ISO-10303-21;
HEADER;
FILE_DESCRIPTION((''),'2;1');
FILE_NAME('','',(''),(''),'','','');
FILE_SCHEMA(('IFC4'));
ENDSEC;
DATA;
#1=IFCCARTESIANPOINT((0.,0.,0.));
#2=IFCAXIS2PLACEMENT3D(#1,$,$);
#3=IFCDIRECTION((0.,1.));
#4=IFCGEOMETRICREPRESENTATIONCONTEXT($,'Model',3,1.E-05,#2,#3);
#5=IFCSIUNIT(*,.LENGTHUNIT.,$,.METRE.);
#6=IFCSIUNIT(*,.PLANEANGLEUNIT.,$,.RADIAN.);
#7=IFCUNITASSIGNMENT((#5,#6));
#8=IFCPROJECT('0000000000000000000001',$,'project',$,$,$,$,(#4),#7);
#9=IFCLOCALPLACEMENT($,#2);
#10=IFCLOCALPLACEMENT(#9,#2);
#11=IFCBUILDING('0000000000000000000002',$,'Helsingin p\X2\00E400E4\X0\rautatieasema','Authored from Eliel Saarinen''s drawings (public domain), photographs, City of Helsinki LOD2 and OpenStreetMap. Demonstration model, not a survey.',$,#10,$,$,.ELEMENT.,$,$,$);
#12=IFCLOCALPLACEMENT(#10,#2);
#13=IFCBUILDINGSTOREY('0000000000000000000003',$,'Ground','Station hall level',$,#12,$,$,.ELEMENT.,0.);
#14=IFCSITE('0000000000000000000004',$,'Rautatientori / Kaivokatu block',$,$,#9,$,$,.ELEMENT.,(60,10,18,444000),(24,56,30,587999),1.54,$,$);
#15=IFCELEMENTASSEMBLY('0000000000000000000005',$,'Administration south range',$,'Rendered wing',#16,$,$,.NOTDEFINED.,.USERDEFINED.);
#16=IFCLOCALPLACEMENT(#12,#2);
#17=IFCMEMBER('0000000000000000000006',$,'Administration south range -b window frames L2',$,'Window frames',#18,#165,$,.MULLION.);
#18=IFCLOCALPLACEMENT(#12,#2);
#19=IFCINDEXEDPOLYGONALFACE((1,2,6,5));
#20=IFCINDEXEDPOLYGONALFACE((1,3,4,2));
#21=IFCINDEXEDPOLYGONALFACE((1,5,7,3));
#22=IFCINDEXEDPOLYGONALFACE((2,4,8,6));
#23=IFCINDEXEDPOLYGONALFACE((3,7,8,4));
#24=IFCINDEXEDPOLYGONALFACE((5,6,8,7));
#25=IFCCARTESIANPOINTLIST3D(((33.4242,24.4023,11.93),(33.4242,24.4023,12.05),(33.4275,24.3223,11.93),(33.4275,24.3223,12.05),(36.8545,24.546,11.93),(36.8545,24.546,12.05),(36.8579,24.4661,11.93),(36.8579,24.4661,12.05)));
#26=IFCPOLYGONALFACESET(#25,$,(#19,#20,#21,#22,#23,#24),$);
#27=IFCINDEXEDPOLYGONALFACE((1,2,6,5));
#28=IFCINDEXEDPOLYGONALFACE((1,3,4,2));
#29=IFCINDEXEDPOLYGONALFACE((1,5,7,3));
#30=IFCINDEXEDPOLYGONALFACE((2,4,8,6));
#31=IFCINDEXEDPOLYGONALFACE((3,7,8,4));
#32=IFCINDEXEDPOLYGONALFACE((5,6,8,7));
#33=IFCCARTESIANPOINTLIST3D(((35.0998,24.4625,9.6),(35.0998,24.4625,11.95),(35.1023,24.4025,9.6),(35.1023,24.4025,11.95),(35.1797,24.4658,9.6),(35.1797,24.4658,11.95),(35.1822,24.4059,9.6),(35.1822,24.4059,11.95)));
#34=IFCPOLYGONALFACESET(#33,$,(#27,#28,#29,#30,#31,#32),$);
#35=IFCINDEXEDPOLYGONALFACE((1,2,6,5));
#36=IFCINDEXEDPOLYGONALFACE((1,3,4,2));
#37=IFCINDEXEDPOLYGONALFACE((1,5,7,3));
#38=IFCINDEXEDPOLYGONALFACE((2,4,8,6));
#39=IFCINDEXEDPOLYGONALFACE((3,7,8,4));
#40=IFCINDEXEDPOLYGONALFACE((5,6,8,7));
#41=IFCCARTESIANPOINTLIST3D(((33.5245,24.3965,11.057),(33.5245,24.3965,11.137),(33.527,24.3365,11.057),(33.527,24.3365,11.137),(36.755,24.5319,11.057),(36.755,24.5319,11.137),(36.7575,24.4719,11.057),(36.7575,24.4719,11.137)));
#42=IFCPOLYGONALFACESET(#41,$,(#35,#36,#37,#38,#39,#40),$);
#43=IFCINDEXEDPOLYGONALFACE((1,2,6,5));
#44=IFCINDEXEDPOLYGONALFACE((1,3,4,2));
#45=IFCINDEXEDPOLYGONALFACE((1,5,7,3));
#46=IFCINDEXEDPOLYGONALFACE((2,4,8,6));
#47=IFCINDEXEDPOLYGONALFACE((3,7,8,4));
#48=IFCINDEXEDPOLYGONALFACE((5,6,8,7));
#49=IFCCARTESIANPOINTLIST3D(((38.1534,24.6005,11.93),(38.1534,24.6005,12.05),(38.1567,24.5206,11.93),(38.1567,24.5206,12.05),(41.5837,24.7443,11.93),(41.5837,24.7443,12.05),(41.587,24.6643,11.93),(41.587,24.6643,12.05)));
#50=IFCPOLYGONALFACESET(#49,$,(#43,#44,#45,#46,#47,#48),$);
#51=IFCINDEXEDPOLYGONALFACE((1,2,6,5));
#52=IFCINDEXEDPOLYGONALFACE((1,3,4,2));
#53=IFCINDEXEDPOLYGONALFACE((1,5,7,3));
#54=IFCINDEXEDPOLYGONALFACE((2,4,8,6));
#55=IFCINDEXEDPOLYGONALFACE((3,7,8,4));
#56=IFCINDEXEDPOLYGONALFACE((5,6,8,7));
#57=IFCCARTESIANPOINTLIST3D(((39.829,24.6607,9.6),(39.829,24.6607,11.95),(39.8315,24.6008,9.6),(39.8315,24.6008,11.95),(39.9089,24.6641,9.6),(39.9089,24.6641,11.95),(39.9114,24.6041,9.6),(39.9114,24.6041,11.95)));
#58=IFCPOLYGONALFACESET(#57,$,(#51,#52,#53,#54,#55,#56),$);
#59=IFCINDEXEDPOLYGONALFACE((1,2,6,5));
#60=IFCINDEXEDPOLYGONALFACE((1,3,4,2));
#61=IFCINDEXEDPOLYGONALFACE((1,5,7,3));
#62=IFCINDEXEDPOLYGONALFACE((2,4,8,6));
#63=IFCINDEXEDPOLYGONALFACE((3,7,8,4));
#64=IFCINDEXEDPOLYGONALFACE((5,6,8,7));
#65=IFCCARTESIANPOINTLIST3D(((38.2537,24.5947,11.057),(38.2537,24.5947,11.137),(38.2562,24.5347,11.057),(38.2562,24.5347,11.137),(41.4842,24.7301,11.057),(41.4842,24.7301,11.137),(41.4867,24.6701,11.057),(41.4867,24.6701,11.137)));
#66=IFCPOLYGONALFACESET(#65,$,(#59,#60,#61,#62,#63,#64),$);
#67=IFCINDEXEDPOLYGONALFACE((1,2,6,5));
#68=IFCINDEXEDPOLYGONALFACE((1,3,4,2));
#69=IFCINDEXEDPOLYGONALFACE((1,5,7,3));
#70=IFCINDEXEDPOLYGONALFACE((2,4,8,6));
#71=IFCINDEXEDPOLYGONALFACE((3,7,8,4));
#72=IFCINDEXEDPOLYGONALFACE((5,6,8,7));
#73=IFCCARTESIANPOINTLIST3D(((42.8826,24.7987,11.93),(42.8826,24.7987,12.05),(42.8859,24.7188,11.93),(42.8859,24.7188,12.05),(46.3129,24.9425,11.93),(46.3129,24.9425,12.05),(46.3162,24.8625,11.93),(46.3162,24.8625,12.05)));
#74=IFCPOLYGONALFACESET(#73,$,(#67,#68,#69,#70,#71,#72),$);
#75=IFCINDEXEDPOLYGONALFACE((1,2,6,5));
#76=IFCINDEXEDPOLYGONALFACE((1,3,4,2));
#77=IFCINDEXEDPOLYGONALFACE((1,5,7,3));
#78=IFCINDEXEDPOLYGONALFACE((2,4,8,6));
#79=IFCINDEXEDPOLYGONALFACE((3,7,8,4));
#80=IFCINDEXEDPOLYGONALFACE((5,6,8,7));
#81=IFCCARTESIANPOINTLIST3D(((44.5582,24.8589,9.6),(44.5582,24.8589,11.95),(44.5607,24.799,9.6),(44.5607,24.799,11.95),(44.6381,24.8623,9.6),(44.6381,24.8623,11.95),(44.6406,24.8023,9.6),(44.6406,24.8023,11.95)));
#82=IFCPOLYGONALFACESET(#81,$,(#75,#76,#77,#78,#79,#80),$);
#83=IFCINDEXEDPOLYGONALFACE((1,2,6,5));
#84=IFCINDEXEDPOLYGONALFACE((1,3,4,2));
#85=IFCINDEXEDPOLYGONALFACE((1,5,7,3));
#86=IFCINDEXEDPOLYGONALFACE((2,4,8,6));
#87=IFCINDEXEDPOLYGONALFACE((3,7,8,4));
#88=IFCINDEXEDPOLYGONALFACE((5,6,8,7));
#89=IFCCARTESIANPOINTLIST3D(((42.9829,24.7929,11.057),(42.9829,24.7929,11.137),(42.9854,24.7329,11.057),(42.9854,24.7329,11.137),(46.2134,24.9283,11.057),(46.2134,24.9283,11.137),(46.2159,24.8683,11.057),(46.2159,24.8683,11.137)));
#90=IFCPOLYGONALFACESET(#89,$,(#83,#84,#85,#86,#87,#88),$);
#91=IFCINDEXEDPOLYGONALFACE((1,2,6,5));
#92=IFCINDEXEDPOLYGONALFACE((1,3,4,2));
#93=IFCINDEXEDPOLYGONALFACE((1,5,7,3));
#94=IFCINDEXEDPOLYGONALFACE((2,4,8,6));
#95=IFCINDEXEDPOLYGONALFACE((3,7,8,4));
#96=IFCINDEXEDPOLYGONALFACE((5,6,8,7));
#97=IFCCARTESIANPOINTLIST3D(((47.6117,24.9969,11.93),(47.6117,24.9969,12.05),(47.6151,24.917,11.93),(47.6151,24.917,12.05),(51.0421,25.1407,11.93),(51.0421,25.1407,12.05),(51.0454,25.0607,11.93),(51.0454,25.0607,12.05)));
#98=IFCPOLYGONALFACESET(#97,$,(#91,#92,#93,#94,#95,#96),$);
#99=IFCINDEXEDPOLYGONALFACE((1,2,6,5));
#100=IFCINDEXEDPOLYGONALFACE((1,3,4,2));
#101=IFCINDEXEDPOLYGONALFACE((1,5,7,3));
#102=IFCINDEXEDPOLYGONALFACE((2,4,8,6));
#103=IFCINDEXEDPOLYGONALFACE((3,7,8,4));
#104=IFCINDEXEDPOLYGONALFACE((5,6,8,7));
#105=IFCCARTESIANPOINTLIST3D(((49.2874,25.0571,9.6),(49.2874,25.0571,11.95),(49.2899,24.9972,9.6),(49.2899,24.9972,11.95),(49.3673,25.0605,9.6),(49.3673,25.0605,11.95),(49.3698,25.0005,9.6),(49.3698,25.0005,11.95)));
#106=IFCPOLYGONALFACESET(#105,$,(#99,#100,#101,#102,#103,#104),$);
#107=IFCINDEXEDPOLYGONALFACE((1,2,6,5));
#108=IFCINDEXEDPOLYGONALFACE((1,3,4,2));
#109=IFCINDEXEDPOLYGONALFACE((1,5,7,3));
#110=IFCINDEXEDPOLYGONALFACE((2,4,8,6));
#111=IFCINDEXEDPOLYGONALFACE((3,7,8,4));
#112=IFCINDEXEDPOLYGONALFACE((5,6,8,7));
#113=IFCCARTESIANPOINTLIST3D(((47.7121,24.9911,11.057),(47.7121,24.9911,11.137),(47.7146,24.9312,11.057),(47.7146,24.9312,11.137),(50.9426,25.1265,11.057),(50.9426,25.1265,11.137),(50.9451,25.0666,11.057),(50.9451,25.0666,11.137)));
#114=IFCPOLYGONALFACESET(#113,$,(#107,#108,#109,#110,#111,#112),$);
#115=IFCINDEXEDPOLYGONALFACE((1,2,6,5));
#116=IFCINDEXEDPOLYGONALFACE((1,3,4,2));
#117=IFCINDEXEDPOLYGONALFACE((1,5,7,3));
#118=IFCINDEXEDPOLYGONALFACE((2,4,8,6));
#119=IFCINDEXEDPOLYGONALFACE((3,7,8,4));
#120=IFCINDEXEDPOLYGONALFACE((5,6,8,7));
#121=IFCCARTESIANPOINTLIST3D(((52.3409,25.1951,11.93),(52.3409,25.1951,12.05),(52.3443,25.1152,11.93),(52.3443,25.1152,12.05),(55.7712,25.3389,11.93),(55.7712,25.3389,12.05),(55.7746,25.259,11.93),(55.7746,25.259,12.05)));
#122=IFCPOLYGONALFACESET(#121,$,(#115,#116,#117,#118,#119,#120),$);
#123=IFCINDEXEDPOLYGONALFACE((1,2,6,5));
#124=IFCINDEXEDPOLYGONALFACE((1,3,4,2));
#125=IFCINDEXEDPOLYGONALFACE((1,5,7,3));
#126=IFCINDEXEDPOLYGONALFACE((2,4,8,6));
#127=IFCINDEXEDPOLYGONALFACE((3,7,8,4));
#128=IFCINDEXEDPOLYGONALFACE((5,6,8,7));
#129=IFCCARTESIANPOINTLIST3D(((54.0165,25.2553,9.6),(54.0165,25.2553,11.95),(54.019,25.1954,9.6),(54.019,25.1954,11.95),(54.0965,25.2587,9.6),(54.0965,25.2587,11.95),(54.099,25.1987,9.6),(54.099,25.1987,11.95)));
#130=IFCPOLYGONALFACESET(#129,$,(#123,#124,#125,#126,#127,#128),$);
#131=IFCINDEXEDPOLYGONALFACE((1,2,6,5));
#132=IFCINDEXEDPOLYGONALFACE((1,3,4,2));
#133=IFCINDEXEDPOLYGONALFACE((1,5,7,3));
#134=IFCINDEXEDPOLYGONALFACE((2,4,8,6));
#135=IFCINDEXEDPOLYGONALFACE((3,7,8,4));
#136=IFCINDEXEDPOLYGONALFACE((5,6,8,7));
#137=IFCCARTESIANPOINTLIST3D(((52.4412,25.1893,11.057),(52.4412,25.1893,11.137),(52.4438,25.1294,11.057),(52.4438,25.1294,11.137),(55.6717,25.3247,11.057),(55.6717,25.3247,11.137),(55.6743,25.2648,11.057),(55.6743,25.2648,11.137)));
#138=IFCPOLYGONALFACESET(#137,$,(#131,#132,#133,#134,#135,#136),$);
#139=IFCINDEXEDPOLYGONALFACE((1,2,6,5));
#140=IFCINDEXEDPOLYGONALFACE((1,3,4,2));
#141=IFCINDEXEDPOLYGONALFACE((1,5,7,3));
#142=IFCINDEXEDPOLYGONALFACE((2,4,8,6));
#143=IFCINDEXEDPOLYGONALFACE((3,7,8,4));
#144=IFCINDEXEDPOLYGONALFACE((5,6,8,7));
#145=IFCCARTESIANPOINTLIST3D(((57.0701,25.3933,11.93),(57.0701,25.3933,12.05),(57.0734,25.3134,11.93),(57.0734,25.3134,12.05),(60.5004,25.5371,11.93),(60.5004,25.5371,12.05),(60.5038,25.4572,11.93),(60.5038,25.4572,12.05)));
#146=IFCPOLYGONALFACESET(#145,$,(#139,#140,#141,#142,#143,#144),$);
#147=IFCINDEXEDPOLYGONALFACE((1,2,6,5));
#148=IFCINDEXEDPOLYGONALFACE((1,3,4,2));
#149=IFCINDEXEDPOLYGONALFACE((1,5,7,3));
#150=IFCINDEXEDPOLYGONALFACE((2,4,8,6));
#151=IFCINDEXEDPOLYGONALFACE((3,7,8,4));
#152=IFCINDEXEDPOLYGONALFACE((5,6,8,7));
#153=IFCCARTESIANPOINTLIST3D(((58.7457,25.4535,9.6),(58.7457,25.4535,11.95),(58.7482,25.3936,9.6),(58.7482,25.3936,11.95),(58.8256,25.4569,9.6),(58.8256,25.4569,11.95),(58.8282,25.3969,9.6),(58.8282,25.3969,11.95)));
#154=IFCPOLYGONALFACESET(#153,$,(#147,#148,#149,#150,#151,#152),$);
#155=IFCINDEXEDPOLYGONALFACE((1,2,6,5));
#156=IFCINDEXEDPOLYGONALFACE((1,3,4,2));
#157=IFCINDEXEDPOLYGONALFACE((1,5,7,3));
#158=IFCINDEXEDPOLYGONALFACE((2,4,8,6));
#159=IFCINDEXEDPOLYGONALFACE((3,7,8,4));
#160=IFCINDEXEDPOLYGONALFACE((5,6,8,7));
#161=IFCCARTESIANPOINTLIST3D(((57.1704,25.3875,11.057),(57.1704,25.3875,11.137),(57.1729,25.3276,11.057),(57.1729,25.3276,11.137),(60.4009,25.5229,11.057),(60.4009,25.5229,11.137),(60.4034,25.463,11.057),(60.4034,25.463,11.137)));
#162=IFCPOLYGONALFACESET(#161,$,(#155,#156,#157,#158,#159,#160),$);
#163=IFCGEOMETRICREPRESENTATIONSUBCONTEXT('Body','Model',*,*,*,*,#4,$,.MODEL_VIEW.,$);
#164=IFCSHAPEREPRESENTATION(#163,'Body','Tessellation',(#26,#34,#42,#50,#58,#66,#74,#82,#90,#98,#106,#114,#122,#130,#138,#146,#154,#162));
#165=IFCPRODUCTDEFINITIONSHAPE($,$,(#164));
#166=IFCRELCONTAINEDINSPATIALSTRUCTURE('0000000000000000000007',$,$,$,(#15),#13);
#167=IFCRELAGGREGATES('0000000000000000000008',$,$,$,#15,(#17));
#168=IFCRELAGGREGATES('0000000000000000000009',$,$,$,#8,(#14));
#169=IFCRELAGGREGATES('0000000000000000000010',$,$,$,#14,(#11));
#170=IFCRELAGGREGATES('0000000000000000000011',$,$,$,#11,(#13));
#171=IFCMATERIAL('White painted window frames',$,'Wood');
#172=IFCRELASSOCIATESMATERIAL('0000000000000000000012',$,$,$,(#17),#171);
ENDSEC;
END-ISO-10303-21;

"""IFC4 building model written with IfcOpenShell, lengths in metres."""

from ifc_helpers import new_model, si_unit, direction, frame, frame_2d, origin, place, context, subcontext, project, spatial, rectangle, extrude, material, element, aggregate, save


model = new_model("IFC4")

# Units and contexts
model_context = context("Model", 3, precision=1e-05, world=origin(), true_north=direction((0.0, 1.0)))
body_context = subcontext(model_context, "Body", "Model", "MODEL_VIEW")
ifc_project = project(units=[si_unit("LENGTHUNIT", "METRE"), si_unit("PLANEANGLEUNIT", "RADIAN")], contexts=[model_context])

# Site, building, storey
site_placement = place(None, origin())
site = spatial("IfcSite", under=ifc_project, at=site_placement, Name="Rautatientori / Kaivokatu block", CompositionType="ELEMENT", RefLatitude=(60, 10, 18, 444000), RefLongitude=(24, 56, 30, 587999), RefElevation=1.54)
building_placement = place(site_placement, origin())
building = spatial("IfcBuilding", under=site, at=building_placement, Name="Helsingin päärautatieasema", Description="Authored from Eliel Saarinen's drawings (public domain), photographs, City of Helsinki LOD2 and OpenStreetMap. Demonstration model, not a survey.", CompositionType="ELEMENT")
storey_placement = place(building_placement, origin())
storey = spatial("IfcBuildingStorey", under=building, at=storey_placement, Name="Ground", Description="Station hall level", CompositionType="ELEMENT", Elevation=0.0)

# Element assembly, member
assembly_1_placement = place(building_placement, origin())
assembly_1 = element("IfcElementAssembly", 1, at=assembly_1_placement, inside=storey, Name="Administration south range", ObjectType="Rendered wing", AssemblyPlace="NOTDEFINED", PredefinedType="USERDEFINED")
ifc_material_1 = material(Name="White painted window frames", Category="Wood")
member_1_placement = place(building_placement, origin())
member_1 = element("IfcMember", 2, at=member_1_placement, material=ifc_material_1, Name="Administration south range -b window frames L2", ObjectType="Window frames", PredefinedType="MULLION", context=body_context, shape_type="SweptSolid", body=[
    extrude(rectangle(XDim=3.4333, YDim=0.08, at=frame_2d((0.0, 0.0), x_axis=(0.999123, 0.041876))), frame((35.141, 24.4342, 11.93)), (0.0, 0.0, 1.0), 0.12),
    extrude(rectangle(XDim=0.08, YDim=0.06, at=frame_2d((0.0, 0.0), x_axis=(0.999123, 0.041876))), frame((35.141, 24.4342, 9.6)), (0.0, 0.0, 1.0), 2.35),
    extrude(rectangle(XDim=3.2333, YDim=0.06, at=frame_2d((0.0, 0.0), x_axis=(0.999123, 0.041876))), frame((35.141, 24.4342, 11.057)), (0.0, 0.0, 1.0), 0.08),
    extrude(rectangle(XDim=3.4333, YDim=0.08, at=frame_2d((0.0, 0.0), x_axis=(0.999123, 0.041876))), frame((39.8702, 24.6324, 11.93)), (0.0, 0.0, 1.0), 0.12),
    extrude(rectangle(XDim=0.08, YDim=0.06, at=frame_2d((0.0, 0.0), x_axis=(0.999123, 0.041876))), frame((39.8702, 24.6324, 9.6)), (0.0, 0.0, 1.0), 2.35),
    extrude(rectangle(XDim=3.2333, YDim=0.06, at=frame_2d((0.0, 0.0), x_axis=(0.999123, 0.041876))), frame((39.8702, 24.6324, 11.057)), (0.0, 0.0, 1.0), 0.08),
    extrude(rectangle(XDim=3.4333, YDim=0.08, at=frame_2d((0.0, 0.0), x_axis=(0.999123, 0.041876))), frame((44.5994, 24.8306, 11.93)), (0.0, 0.0, 1.0), 0.12),
    extrude(rectangle(XDim=0.08, YDim=0.06, at=frame_2d((0.0, 0.0), x_axis=(0.999123, 0.041876))), frame((44.5994, 24.8306, 9.6)), (0.0, 0.0, 1.0), 2.35),
    extrude(rectangle(XDim=3.2333, YDim=0.06, at=frame_2d((0.0, 0.0), x_axis=(0.999123, 0.041876))), frame((44.5994, 24.8306, 11.057)), (0.0, 0.0, 1.0), 0.08),
    extrude(rectangle(XDim=3.4333, YDim=0.08, at=frame_2d((0.0, 0.0), x_axis=(0.999123, 0.041876))), frame((49.3286, 25.0288, 11.93)), (0.0, 0.0, 1.0), 0.12),
    extrude(rectangle(XDim=0.08, YDim=0.06, at=frame_2d((0.0, 0.0), x_axis=(0.999123, 0.041876))), frame((49.3286, 25.0288, 9.6)), (0.0, 0.0, 1.0), 2.35),
    extrude(rectangle(XDim=3.2333, YDim=0.06, at=frame_2d((0.0, 0.0), x_axis=(0.999123, 0.041876))), frame((49.3286, 25.0288, 11.057)), (0.0, 0.0, 1.0), 0.08),
    extrude(rectangle(XDim=3.4333, YDim=0.08, at=frame_2d((0.0, 0.0), x_axis=(0.999123, 0.041876))), frame((54.0578, 25.227, 11.93)), (0.0, 0.0, 1.0), 0.12),
    extrude(rectangle(XDim=0.08, YDim=0.06, at=frame_2d((0.0, 0.0), x_axis=(0.999123, 0.041876))), frame((54.0578, 25.227, 9.6)), (0.0, 0.0, 1.0), 2.35),
    extrude(rectangle(XDim=3.2333, YDim=0.06, at=frame_2d((0.0, 0.0), x_axis=(0.999123, 0.041876))), frame((54.0578, 25.227, 11.057)), (0.0, 0.0, 1.0), 0.08),
    extrude(rectangle(XDim=3.4333, YDim=0.08, at=frame_2d((0.0, 0.0), x_axis=(0.999123, 0.041876))), frame((58.7869, 25.4252, 11.93)), (0.0, 0.0, 1.0), 0.12),
    extrude(rectangle(XDim=0.08, YDim=0.06, at=frame_2d((0.0, 0.0), x_axis=(0.999123, 0.041876))), frame((58.7869, 25.4252, 9.6)), (0.0, 0.0, 1.0), 2.35),
    extrude(rectangle(XDim=3.2333, YDim=0.06, at=frame_2d((0.0, 0.0), x_axis=(0.999123, 0.041876))), frame((58.7869, 25.4252, 11.057)), (0.0, 0.0, 1.0), 0.08),
])

aggregate(assembly_1, [member_1])

save(model, "model.ifc")
